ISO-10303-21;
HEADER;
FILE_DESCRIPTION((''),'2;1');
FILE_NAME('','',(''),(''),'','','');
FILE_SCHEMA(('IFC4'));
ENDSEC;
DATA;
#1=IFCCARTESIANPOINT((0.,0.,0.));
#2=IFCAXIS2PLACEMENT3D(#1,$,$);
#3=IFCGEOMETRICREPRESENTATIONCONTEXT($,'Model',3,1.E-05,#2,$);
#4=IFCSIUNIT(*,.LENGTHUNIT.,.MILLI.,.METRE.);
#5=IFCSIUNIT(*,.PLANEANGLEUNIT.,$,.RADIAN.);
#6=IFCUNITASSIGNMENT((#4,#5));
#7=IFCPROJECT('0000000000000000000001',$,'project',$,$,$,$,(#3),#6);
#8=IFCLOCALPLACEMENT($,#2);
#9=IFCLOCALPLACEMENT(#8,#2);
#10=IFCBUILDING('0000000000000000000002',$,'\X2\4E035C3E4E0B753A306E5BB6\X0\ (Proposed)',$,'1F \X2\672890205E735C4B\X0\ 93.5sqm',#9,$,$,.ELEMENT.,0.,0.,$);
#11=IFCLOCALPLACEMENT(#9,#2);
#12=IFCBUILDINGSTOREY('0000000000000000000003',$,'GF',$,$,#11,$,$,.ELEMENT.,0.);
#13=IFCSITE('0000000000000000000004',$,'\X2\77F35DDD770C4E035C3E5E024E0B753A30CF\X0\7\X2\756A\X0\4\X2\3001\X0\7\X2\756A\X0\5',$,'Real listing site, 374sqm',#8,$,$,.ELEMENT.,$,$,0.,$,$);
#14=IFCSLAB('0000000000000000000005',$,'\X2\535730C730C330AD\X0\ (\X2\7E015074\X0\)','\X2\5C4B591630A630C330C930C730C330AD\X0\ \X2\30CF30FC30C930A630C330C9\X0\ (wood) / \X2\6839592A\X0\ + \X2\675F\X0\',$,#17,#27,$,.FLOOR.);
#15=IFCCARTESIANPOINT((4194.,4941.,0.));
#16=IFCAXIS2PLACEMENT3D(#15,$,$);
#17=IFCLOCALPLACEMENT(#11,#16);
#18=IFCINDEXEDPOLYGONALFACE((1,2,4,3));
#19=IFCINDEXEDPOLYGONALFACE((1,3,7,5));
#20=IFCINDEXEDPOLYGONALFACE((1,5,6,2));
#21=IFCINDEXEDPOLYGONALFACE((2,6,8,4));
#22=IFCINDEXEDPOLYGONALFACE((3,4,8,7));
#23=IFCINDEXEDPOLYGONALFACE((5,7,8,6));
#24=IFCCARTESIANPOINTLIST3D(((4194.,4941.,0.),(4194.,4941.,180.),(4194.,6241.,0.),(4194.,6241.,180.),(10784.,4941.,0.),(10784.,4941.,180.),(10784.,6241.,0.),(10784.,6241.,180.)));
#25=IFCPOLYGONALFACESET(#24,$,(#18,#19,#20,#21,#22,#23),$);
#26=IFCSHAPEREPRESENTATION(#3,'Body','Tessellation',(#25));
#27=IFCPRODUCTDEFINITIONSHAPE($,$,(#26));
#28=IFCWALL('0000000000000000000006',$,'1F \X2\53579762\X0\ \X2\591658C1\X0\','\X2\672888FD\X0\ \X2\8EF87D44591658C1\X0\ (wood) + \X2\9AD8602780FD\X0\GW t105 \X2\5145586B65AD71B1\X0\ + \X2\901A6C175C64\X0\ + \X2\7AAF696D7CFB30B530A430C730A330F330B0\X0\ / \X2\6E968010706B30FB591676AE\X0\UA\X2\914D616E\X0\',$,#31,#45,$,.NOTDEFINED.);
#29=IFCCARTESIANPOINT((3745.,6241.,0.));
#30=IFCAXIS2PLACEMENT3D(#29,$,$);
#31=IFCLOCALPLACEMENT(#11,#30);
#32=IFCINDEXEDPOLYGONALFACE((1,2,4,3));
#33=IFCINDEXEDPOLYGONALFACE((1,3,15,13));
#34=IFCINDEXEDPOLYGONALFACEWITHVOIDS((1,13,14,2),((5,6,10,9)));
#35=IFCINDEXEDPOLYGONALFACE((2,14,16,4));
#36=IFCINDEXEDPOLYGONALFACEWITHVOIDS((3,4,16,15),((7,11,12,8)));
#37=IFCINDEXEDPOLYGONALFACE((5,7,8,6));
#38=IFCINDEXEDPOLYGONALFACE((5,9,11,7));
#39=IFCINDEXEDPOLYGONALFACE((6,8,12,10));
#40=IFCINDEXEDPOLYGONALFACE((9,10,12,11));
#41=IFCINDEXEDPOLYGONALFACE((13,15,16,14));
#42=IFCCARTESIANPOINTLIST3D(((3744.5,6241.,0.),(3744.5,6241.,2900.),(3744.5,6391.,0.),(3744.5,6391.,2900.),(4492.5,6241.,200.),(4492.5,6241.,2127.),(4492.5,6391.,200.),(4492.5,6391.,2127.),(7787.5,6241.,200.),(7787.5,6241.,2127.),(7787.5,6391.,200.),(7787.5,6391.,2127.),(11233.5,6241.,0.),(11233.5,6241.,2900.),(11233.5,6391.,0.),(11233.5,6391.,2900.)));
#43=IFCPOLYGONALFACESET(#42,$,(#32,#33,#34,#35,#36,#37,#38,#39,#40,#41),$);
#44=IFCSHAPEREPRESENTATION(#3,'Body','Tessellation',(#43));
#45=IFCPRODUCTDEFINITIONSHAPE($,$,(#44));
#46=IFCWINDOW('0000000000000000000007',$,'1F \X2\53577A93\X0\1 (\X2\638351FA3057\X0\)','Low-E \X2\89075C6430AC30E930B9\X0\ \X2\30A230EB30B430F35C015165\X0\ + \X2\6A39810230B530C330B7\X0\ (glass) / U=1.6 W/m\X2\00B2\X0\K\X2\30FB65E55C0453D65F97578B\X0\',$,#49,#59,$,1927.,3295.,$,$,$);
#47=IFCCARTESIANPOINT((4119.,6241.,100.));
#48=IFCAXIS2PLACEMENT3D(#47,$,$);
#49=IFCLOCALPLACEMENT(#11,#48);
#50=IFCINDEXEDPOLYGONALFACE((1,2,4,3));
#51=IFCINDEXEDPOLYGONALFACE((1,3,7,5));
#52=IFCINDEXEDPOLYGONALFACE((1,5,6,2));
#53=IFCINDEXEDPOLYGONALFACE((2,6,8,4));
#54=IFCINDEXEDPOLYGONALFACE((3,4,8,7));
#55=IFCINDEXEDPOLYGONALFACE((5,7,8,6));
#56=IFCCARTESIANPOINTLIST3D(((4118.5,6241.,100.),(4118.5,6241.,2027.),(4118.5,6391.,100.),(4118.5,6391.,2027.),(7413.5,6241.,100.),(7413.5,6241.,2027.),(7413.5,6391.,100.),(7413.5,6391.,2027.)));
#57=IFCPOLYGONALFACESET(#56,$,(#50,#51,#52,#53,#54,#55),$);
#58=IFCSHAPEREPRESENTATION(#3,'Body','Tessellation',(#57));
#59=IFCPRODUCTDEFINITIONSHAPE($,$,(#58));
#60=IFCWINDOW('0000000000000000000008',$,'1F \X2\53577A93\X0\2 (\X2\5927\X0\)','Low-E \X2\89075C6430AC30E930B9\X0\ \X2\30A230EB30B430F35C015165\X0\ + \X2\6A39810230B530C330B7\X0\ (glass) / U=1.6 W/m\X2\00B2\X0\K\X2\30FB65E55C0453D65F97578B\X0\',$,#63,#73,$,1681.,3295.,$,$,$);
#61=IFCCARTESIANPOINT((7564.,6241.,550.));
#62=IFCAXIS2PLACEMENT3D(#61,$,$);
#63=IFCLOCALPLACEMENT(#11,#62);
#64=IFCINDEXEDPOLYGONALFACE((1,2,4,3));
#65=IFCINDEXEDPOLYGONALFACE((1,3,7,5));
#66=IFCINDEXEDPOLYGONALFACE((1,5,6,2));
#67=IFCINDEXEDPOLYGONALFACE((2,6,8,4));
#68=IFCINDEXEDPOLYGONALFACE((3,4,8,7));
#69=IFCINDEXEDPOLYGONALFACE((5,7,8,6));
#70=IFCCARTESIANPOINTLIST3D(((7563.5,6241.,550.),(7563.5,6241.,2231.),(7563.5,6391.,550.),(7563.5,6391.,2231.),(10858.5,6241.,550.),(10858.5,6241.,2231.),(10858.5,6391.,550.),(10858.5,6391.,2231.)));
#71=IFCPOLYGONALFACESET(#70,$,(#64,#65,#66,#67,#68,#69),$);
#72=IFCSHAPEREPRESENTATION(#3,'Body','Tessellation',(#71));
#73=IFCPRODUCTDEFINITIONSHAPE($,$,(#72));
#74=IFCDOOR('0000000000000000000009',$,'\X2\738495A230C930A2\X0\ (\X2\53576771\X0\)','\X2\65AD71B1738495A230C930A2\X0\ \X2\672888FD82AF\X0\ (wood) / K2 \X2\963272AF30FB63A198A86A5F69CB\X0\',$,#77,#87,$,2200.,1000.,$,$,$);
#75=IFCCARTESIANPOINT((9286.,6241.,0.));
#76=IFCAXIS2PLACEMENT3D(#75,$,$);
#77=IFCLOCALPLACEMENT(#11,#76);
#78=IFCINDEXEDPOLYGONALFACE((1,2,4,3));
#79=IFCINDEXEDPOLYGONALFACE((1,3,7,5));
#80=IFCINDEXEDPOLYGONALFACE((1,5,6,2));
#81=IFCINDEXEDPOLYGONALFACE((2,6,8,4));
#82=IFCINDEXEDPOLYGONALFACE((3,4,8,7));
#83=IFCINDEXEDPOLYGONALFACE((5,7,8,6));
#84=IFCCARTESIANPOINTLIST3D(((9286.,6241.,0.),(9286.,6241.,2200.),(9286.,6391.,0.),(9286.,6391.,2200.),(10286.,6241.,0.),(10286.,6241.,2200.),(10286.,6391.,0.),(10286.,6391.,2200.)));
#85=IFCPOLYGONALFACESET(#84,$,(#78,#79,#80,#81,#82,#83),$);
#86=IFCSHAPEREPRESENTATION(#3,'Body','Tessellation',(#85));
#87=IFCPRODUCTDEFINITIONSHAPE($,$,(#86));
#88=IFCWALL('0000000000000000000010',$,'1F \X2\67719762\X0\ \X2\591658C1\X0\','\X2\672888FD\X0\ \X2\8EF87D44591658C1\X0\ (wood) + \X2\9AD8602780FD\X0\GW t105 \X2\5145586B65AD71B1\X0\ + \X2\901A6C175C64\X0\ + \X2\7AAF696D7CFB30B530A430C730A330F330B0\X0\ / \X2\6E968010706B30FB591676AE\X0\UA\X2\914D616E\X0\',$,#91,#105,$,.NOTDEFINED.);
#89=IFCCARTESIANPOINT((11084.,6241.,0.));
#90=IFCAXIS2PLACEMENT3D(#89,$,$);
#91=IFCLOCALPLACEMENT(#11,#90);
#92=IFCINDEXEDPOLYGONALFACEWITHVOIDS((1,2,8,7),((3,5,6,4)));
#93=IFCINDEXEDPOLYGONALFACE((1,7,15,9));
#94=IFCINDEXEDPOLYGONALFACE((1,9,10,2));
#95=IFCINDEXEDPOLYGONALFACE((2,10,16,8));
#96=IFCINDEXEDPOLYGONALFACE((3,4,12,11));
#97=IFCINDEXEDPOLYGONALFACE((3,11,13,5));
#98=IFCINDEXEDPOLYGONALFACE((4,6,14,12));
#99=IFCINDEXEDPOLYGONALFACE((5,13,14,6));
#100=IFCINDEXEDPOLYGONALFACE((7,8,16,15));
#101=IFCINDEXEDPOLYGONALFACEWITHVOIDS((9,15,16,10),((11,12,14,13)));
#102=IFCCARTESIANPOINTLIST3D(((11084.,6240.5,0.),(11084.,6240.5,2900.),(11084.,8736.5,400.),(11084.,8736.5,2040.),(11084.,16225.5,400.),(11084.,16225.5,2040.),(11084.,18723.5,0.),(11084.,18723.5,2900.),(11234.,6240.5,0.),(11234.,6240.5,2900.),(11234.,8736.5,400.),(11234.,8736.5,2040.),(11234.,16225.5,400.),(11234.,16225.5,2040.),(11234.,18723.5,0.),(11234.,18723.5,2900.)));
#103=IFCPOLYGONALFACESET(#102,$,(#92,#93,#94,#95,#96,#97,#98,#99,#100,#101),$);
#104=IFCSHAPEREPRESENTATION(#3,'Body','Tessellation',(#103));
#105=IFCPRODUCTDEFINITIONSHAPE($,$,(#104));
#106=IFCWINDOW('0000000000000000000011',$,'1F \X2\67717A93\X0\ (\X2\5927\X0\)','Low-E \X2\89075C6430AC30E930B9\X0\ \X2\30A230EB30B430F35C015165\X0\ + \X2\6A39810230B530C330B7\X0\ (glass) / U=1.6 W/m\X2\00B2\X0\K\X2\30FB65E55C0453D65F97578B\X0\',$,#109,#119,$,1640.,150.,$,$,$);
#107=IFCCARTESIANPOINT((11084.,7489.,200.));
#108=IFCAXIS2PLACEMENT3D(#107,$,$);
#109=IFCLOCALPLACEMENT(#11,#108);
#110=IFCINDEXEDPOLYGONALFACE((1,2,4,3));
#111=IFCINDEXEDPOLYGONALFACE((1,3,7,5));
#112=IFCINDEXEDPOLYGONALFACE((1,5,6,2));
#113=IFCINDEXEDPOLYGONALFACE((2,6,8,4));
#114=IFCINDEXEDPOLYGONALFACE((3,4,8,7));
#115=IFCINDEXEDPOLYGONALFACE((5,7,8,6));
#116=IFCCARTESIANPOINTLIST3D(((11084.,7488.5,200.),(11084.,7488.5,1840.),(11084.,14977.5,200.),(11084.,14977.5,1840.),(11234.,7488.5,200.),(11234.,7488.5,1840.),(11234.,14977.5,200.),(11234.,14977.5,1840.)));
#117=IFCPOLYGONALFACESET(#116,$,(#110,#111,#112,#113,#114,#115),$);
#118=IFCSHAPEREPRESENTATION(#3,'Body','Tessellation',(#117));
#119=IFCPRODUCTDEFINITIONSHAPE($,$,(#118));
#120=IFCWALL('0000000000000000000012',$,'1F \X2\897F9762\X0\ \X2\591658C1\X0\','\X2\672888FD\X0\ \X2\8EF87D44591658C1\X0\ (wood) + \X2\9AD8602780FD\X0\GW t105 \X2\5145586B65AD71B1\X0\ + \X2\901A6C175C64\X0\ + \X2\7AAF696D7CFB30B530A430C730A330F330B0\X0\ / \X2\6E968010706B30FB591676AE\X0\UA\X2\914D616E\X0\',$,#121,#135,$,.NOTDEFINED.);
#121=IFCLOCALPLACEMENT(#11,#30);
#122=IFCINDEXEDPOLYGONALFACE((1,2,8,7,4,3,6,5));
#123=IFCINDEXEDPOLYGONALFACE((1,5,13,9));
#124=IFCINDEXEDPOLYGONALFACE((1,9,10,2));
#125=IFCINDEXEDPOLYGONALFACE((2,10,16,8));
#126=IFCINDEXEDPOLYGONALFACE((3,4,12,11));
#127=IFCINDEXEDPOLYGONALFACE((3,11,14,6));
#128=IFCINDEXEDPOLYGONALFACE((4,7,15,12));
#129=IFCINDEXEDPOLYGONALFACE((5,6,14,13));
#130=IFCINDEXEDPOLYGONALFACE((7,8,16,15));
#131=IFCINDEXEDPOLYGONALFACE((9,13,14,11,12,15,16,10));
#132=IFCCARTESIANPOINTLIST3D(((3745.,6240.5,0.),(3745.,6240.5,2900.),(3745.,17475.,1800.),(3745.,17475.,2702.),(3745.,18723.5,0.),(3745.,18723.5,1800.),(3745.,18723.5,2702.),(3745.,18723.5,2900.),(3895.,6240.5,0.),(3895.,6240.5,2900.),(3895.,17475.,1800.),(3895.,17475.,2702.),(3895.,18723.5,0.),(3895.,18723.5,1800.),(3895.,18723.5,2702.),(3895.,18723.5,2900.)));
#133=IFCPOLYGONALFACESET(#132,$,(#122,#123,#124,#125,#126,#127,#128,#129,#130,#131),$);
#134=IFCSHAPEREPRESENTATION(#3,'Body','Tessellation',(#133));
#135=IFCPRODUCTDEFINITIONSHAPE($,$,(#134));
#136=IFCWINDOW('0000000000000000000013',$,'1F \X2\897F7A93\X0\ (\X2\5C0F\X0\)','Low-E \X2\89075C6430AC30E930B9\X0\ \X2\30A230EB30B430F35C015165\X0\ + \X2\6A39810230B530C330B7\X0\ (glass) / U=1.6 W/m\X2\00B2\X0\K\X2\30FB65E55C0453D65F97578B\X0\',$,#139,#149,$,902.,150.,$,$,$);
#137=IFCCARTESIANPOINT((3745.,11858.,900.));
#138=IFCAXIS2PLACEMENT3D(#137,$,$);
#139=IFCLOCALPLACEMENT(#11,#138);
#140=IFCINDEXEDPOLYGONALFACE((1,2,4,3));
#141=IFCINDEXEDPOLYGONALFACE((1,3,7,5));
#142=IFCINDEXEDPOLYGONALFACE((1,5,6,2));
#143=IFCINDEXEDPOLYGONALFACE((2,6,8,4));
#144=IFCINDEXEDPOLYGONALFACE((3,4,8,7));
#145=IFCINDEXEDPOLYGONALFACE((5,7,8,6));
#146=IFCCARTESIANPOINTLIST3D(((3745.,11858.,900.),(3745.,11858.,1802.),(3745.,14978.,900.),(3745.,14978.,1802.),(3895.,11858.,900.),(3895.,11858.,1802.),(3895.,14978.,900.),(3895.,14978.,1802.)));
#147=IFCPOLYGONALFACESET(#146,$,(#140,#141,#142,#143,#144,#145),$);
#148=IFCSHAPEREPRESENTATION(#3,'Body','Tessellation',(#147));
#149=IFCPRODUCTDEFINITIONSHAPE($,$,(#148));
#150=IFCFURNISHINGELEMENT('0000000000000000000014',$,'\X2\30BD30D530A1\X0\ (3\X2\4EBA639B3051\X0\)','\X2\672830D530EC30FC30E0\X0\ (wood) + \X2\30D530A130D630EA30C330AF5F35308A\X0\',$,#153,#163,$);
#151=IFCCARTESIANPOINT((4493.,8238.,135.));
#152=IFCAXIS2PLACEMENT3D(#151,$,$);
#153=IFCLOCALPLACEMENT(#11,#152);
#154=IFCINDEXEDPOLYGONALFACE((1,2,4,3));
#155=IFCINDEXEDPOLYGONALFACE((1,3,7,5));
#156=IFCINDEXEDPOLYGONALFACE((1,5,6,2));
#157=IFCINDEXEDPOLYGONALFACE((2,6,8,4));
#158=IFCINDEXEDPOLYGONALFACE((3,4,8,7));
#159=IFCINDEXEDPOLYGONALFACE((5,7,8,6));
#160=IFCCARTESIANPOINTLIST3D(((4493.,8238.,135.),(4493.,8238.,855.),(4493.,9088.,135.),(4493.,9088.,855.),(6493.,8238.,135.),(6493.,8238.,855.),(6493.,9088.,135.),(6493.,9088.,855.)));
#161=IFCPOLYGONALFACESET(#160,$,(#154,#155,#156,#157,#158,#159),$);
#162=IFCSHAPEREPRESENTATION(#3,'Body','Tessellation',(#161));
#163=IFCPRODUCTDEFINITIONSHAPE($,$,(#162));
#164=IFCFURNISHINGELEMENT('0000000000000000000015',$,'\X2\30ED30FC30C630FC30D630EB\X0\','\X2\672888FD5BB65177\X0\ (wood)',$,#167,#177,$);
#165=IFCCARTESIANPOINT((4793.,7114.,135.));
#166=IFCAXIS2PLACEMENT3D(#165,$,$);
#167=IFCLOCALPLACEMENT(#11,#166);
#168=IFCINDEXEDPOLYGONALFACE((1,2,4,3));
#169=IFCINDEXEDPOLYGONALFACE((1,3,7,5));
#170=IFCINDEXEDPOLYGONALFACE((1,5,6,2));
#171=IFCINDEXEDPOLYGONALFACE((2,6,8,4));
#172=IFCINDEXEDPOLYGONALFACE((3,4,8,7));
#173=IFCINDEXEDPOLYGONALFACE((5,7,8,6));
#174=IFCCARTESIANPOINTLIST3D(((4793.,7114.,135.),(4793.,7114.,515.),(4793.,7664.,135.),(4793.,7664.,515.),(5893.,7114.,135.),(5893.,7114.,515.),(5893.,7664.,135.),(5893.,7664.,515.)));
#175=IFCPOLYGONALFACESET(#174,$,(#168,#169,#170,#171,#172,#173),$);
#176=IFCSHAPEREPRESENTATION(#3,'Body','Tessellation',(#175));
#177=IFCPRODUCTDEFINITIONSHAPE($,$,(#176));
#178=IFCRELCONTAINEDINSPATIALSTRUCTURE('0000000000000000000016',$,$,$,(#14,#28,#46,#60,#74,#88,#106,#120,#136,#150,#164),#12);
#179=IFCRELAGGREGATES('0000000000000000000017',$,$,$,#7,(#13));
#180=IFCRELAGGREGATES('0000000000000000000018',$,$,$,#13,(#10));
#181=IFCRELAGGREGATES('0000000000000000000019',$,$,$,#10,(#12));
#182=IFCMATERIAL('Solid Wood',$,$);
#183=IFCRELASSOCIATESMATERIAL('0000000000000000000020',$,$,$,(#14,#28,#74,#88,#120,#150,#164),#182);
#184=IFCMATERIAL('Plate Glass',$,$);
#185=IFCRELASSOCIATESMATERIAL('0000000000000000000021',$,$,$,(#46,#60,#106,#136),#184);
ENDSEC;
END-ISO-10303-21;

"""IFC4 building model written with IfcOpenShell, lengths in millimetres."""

from ifc_helpers import new_model, si_unit, frame, frame_2d, origin, place, context, project, spatial, rectangle, extrude, material, element, fill, save


model = new_model("IFC4")

# Units and contexts
model_context = context("Model", 3, precision=1e-05, world=origin())
ifc_project = project(units=[si_unit("LENGTHUNIT", "METRE", prefix="MILLI"), si_unit("PLANEANGLEUNIT", "RADIAN")], contexts=[model_context])

# Site, building, storey
site_placement = place(None, origin())
site = spatial("IfcSite", under=ifc_project, at=site_placement, Name="石川県七尾市下町ハ7番4、7番5", ObjectType="Real listing site, 374sqm", CompositionType="ELEMENT", RefElevation=0.0)
building_placement = place(site_placement, origin())
building = spatial("IfcBuilding", under=site, at=building_placement, Name="七尾下町の家 (Proposed)", ObjectType="1F 木造平屋 93.5sqm", CompositionType="ELEMENT", ElevationOfRefHeight=0.0, ElevationOfTerrain=0.0)
storey_placement = place(building_placement, origin())
storey = spatial("IfcBuildingStorey", under=building, at=storey_placement, Name="GF", CompositionType="ELEMENT", Elevation=0.0)

# Slab
ifc_material_1 = material(Name="Solid Wood")
slab_1_placement = place(storey_placement, frame((4194.0, 4941.0, 0.0)))
element("IfcSlab", 1, at=slab_1_placement, inside=storey, material=ifc_material_1, Name="南デッキ (縁側)", Description="屋外ウッドデッキ ハードウッド (wood) / 根太 + 束", PredefinedType="FLOOR", context=model_context, shape_type="SweptSolid", body=[
    extrude(rectangle(XDim=6590.0, YDim=1300.0, at=frame_2d((3295.0, 650.0))), frame((4194.0, 4941.0, 0.0)), (0.0, 0.0, 1.0), 180.0),
])

# Wall, openings, windows, door
wall_1_placement = place(storey_placement, frame((3745.0, 6241.0, 0.0)))
wall_1 = element("IfcWall", 2, at=wall_1_placement, inside=storey, material=ifc_material_1, Name="1F 南面 外壁", Description="木製 軸組外壁 (wood) + 高性能GW t105 充填断熱 + 通気層 + 窯業系サイディング / 準耐火・外皮UA配慮", PredefinedType="NOTDEFINED", context=model_context, shape_type="SweptSolid", body=[
    extrude(rectangle(XDim=7489.0, YDim=150.0, at=frame_2d((3744.0, 75.0))), frame((3745.0, 6241.0, 0.0)), (0.0, 0.0, 1.0), 2900.0),
])
opening_1_placement = place(storey_placement, frame((4119.0, 6241.0, 100.0)))
opening_1 = element("IfcOpeningElement", 3, at=opening_1_placement, cuts=wall_1, PredefinedType="NOTDEFINED", context=model_context, shape_type="SweptSolid", body=[
    extrude(rectangle(XDim=3295.0, YDim=150.0, at=frame_2d((1647.0, 75.0))), frame((4119.0, 6241.0, 100.0)), (0.0, 0.0, 1.0), 1927.0),
])
opening_2_placement = place(storey_placement, frame((7564.0, 6241.0, 550.0)))
opening_2 = element("IfcOpeningElement", 4, at=opening_2_placement, cuts=wall_1, PredefinedType="NOTDEFINED", context=model_context, shape_type="SweptSolid", body=[
    extrude(rectangle(XDim=3295.0, YDim=150.0, at=frame_2d((1647.0, 75.0))), frame((7564.0, 6241.0, 550.0)), (0.0, 0.0, 1.0), 1681.0),
])
opening_3_placement = place(storey_placement, frame((9286.0, 6241.0, 0.0)))
opening_3 = element("IfcOpeningElement", 5, at=opening_3_placement, cuts=wall_1, PredefinedType="NOTDEFINED", context=model_context, shape_type="SweptSolid", body=[
    extrude(rectangle(XDim=1000.0, YDim=150.0, at=frame_2d((500.0, 75.0))), frame((9286.0, 6241.0, 0.0)), (0.0, 0.0, 1.0), 2200.0),
])
ifc_material_2 = material(Name="Plate Glass")
window_1_placement = place(storey_placement, frame((4119.0, 6241.0, 100.0)))
window_1 = element("IfcWindow", 6, at=window_1_placement, inside=storey, material=ifc_material_2, Name="1F 南窓1 (掃出し)", Description="Low-E 複層ガラス アルゴン封入 + 樹脂サッシ (glass) / U=1.6 W/m²K・日射取得型", OverallHeight=1927.0, OverallWidth=3295.0, context=model_context, shape_type="SweptSolid", body=[
    extrude(rectangle(XDim=3295.0, YDim=150.0, at=frame_2d((1647.0, 75.0))), frame((4119.0, 6241.0, 100.0)), (0.0, 0.0, 1.0), 1927.0),
])
fill(opening_1, window_1)
window_2_placement = place(storey_placement, frame((7564.0, 6241.0, 550.0)))
window_2 = element("IfcWindow", 7, at=window_2_placement, inside=storey, material=ifc_material_2, Name="1F 南窓2 (大)", Description="Low-E 複層ガラス アルゴン封入 + 樹脂サッシ (glass) / U=1.6 W/m²K・日射取得型", OverallHeight=1681.0, OverallWidth=3295.0, context=model_context, shape_type="SweptSolid", body=[
    extrude(rectangle(XDim=3295.0, YDim=150.0, at=frame_2d((1647.0, 75.0))), frame((7564.0, 6241.0, 550.0)), (0.0, 0.0, 1.0), 1681.0),
])
fill(opening_2, window_2)
door_placement = place(storey_placement, frame((9286.0, 6241.0, 0.0)))
door = element("IfcDoor", 8, at=door_placement, inside=storey, material=ifc_material_1, Name="玄関ドア (南東)", Description="断熱玄関ドア 木製芯 (wood) / K2 防犯・採風機構", OverallHeight=2200.0, OverallWidth=1000.0, context=model_context, shape_type="SweptSolid", body=[
    extrude(rectangle(XDim=1000.0, YDim=150.0, at=frame_2d((500.0, 75.0))), frame((9286.0, 6241.0, 0.0)), (0.0, 0.0, 1.0), 2200.0),
])
fill(opening_3, door)

# Walls, openings, windows
wall_2_placement = place(storey_placement, frame((11084.0, 6241.0, 0.0)))
wall_2 = element("IfcWall", 9, at=wall_2_placement, inside=storey, material=ifc_material_1, Name="1F 東面 外壁", Description="木製 軸組外壁 (wood) + 高性能GW t105 充填断熱 + 通気層 + 窯業系サイディング / 準耐火・外皮UA配慮", PredefinedType="NOTDEFINED", context=model_context, shape_type="SweptSolid", body=[
    extrude(rectangle(XDim=150.0, YDim=12483.0, at=frame_2d((75.0, 6241.0))), frame((11084.0, 6241.0, 0.0)), (0.0, 0.0, 1.0), 2900.0),
])
opening_4_placement = place(storey_placement, frame((11084.0, 7489.0, 200.0)))
opening_4 = element("IfcOpeningElement", 10, at=opening_4_placement, cuts=wall_2, PredefinedType="NOTDEFINED", context=model_context, shape_type="SweptSolid", body=[
    extrude(rectangle(XDim=150.0, YDim=7489.0, at=frame_2d((75.0, 3744.0))), frame((11084.0, 7489.0, 200.0)), (0.0, 0.0, 1.0), 1640.0),
])
window_3_placement = place(storey_placement, frame((11084.0, 7489.0, 200.0)))
window_3 = element("IfcWindow", 11, at=window_3_placement, inside=storey, material=ifc_material_2, Name="1F 東窓 (大)", Description="Low-E 複層ガラス アルゴン封入 + 樹脂サッシ (glass) / U=1.6 W/m²K・日射取得型", OverallHeight=1640.0, OverallWidth=150.0, context=model_context, shape_type="SweptSolid", body=[
    extrude(rectangle(XDim=150.0, YDim=7489.0, at=frame_2d((75.0, 3744.0))), frame((11084.0, 7489.0, 200.0)), (0.0, 0.0, 1.0), 1640.0),
])
fill(opening_4, window_3)
wall_3_placement = place(storey_placement, frame((3745.0, 6241.0, 0.0)))
wall_3 = element("IfcWall", 12, at=wall_3_placement, inside=storey, material=ifc_material_1, Name="1F 西面 外壁", Description="木製 軸組外壁 (wood) + 高性能GW t105 充填断熱 + 通気層 + 窯業系サイディング / 準耐火・外皮UA配慮", PredefinedType="NOTDEFINED", context=model_context, shape_type="SweptSolid", body=[
    extrude(rectangle(XDim=150.0, YDim=12483.0, at=frame_2d((75.0, 6241.0))), frame((3745.0, 6241.0, 0.0)), (0.0, 0.0, 1.0), 2900.0),
])
opening_5_placement = place(storey_placement, frame((3745.0, 11858.0, 900.0)))
opening_5 = element("IfcOpeningElement", 13, at=opening_5_placement, cuts=wall_3, PredefinedType="NOTDEFINED", context=model_context, shape_type="SweptSolid", body=[
    extrude(rectangle(XDim=150.0, YDim=3120.0, at=frame_2d((75.0, 1560.0))), frame((3745.0, 11858.0, 900.0)), (0.0, 0.0, 1.0), 902.0),
])
window_4_placement = place(storey_placement, frame((3745.0, 11858.0, 900.0)))
window_4 = element("IfcWindow", 14, at=window_4_placement, inside=storey, material=ifc_material_2, Name="1F 西窓 (小)", Description="Low-E 複層ガラス アルゴン封入 + 樹脂サッシ (glass) / U=1.6 W/m²K・日射取得型", OverallHeight=902.0, OverallWidth=150.0, context=model_context, shape_type="SweptSolid", body=[
    extrude(rectangle(XDim=150.0, YDim=3120.0, at=frame_2d((75.0, 1560.0))), frame((3745.0, 11858.0, 900.0)), (0.0, 0.0, 1.0), 902.0),
])
fill(opening_5, window_4)

# Furnishing elements
furnishing_1_placement = place(storey_placement, frame((4493.0, 8238.0, 135.0)))
element("IfcFurnishingElement", 15, at=furnishing_1_placement, inside=storey, material=ifc_material_1, Name="ソファ (3人掛け)", Description="木フレーム (wood) + ファブリック張り", context=model_context, shape_type="SweptSolid", body=[
    extrude(rectangle(XDim=2000.0, YDim=850.0, at=frame_2d((1000.0, 425.0))), frame((4493.0, 8238.0, 135.0)), (0.0, 0.0, 1.0), 720.0),
])
furnishing_2_placement = place(storey_placement, frame((4793.0, 7114.0, 135.0)))
element("IfcFurnishingElement", 16, at=furnishing_2_placement, inside=storey, material=ifc_material_1, Name="ローテーブル", Description="木製家具 (wood)", context=model_context, shape_type="SweptSolid", body=[
    extrude(rectangle(XDim=1100.0, YDim=550.0, at=frame_2d((550.0, 275.0))), frame((4793.0, 7114.0, 135.0)), (0.0, 0.0, 1.0), 380.0),
])

save(model, "model.ifc")
